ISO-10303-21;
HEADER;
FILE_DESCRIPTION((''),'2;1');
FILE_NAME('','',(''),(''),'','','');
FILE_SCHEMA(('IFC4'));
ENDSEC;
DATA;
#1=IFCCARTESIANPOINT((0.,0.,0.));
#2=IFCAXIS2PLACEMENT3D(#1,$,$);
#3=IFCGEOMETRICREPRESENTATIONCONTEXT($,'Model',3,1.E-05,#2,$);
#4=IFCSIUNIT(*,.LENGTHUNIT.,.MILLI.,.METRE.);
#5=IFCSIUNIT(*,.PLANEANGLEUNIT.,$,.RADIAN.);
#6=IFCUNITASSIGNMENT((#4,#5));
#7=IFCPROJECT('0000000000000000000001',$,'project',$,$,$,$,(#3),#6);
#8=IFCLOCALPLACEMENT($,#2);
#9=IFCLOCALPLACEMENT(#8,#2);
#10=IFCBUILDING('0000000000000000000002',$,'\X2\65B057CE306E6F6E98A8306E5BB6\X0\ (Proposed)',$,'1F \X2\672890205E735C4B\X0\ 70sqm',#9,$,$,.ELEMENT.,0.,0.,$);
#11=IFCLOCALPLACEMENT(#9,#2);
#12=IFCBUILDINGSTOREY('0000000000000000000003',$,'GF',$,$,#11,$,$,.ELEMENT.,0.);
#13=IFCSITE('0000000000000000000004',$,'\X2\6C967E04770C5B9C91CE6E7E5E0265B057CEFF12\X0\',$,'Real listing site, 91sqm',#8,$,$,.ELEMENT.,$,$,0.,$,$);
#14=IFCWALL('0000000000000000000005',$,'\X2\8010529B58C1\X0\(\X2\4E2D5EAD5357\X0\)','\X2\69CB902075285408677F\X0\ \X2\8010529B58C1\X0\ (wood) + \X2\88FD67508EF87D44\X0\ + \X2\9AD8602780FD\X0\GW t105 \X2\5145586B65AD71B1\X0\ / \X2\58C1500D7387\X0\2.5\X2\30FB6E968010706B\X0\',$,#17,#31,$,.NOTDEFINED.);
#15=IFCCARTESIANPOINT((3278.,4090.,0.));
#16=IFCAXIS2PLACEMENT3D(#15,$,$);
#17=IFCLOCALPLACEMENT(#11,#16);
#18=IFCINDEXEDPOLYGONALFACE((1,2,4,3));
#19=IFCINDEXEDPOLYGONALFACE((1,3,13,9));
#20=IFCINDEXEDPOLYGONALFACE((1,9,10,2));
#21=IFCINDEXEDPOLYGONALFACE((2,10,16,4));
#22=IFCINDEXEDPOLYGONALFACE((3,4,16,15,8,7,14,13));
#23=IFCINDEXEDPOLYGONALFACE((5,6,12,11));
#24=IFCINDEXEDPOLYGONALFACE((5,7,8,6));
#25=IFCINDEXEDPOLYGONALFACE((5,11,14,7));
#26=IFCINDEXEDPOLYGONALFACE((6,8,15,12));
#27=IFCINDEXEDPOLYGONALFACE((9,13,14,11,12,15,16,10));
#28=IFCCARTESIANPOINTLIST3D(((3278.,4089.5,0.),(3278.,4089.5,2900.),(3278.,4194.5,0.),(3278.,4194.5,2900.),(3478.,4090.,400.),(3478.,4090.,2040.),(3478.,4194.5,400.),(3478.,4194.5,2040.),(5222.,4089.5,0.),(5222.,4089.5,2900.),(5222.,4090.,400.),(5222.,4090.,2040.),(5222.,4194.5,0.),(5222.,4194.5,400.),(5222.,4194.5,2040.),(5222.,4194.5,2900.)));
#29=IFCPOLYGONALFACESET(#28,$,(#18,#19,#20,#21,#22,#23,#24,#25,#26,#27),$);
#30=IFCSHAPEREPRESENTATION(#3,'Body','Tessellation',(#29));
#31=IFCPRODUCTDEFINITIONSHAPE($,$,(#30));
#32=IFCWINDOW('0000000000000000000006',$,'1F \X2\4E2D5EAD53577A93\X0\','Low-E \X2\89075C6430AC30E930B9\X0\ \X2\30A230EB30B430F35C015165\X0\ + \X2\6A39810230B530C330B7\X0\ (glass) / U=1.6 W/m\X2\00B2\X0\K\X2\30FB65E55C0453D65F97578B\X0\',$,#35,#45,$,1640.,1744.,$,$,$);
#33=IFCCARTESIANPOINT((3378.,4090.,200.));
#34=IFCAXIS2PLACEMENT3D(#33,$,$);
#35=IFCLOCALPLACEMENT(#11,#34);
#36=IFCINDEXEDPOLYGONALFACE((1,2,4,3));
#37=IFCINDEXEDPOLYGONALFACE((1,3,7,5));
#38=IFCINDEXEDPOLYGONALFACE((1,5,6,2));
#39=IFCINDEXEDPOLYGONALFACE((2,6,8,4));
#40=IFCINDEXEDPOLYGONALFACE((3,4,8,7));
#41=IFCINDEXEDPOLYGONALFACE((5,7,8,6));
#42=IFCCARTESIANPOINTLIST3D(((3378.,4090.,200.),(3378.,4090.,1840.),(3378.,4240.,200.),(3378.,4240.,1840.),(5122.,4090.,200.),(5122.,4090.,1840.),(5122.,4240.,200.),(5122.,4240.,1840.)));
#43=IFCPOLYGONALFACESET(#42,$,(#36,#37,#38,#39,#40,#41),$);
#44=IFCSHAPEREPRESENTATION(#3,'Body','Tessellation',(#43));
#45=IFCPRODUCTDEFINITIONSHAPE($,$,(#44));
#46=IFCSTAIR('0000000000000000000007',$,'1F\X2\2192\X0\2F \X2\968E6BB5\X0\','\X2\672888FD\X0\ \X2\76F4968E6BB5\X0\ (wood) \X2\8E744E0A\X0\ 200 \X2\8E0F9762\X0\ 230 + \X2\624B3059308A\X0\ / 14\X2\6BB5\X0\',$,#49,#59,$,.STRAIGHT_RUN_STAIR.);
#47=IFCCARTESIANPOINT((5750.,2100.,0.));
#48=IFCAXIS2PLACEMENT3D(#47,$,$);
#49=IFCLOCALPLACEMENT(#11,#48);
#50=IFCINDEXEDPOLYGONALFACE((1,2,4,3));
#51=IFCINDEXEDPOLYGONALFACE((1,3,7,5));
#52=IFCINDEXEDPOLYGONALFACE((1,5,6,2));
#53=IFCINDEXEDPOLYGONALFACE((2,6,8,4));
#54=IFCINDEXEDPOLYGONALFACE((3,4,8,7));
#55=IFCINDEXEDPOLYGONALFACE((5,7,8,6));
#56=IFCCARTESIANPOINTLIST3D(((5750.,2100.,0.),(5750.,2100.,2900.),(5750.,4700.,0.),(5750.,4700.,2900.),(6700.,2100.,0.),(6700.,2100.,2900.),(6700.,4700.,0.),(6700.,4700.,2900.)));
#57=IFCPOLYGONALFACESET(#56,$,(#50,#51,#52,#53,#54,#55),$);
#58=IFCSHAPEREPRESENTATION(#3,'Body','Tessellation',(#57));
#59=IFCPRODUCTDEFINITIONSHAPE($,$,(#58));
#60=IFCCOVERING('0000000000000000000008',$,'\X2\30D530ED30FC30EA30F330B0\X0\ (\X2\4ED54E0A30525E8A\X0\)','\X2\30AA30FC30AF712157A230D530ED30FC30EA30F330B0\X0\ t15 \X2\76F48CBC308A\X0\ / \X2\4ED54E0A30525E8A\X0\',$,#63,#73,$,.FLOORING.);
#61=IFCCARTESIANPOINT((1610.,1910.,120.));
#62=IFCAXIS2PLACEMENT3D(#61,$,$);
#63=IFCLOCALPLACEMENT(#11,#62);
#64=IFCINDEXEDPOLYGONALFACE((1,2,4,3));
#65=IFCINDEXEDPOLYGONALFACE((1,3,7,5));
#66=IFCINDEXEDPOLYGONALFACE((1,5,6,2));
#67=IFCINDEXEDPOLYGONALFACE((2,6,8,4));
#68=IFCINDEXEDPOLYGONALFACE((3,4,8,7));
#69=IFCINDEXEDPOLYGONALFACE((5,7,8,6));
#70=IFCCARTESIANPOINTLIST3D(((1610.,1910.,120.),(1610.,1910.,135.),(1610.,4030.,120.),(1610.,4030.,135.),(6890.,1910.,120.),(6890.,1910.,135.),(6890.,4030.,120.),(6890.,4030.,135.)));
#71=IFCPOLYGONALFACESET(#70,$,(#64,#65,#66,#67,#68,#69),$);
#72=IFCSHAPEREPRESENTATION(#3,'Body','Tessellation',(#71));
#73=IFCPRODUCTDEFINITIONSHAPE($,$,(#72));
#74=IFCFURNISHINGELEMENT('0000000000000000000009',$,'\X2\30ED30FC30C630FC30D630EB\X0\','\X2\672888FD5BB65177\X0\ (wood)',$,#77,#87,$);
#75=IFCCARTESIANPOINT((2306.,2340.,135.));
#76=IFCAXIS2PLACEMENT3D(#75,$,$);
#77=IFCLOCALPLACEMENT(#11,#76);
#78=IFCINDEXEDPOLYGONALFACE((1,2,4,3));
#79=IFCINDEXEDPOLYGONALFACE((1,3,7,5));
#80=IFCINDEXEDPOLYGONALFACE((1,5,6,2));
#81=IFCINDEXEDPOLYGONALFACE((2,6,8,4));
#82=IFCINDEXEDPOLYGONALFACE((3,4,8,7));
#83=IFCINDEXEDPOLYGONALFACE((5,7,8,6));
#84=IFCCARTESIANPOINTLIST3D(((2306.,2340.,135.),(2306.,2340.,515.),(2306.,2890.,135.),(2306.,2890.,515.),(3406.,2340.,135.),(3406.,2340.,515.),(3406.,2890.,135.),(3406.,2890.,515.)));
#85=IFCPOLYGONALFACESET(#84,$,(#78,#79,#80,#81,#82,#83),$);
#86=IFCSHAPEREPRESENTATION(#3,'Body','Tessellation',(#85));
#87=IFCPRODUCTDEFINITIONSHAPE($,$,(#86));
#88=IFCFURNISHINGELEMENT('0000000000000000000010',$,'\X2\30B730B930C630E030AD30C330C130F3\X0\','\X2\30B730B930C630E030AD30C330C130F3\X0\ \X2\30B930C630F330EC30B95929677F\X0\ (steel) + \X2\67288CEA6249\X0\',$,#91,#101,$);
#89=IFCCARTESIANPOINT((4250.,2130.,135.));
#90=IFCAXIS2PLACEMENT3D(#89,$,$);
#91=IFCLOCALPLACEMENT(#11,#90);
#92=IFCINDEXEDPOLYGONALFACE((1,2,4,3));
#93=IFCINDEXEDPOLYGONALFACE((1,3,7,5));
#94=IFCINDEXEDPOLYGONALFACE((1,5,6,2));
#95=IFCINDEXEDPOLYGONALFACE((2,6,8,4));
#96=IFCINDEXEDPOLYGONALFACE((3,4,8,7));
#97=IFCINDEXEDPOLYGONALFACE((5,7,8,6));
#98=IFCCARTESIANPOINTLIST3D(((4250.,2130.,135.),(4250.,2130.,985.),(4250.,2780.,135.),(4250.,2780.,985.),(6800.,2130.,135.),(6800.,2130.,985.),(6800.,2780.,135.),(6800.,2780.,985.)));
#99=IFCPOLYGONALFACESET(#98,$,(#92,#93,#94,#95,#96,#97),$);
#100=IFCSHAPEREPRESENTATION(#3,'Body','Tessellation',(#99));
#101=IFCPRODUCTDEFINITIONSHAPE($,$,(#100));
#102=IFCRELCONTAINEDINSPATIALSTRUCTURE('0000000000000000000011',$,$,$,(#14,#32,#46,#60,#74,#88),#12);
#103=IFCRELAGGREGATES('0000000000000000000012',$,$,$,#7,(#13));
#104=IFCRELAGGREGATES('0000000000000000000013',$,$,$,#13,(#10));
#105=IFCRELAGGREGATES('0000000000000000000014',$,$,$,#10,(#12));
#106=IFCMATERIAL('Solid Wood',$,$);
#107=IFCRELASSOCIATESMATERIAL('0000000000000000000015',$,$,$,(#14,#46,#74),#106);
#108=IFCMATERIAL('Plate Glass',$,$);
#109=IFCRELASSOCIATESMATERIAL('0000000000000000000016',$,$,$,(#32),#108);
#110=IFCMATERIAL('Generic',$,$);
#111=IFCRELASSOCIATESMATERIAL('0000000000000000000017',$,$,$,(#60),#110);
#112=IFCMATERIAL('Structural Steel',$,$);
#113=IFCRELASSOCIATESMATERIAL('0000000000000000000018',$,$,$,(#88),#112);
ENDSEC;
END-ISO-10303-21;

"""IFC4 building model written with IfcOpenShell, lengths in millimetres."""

from ifc_helpers import new_model, si_unit, frame, frame_2d, origin, place, context, project, spatial, rectangle, extrude, material, element, fill, save


model = new_model("IFC4")

# Units and contexts
model_context = context("Model", 3, precision=1e-05, world=origin())
ifc_project = project(units=[si_unit("LENGTHUNIT", "METRE", prefix="MILLI"), si_unit("PLANEANGLEUNIT", "RADIAN")], contexts=[model_context])

# Site, building, storey
site_placement = place(None, origin())
site = spatial("IfcSite", under=ifc_project, at=site_placement, Name="沖縄県宜野湾市新城２", ObjectType="Real listing site, 91sqm", CompositionType="ELEMENT", RefElevation=0.0)
building_placement = place(site_placement, origin())
building = spatial("IfcBuilding", under=site, at=building_placement, Name="新城の潮風の家 (Proposed)", ObjectType="1F 木造平屋 70sqm", CompositionType="ELEMENT", ElevationOfRefHeight=0.0, ElevationOfTerrain=0.0)
storey_placement = place(building_placement, origin())
storey = spatial("IfcBuildingStorey", under=building, at=storey_placement, Name="GF", CompositionType="ELEMENT", Elevation=0.0)

# Shared definitions
ifc_material_1 = material(Name="Solid Wood")

# Shared definitions
ifc_material_2 = material(Name="Plate Glass")

# Wall, opening, window
wall_1_placement = place(storey_placement, frame((3278.0, 4090.0, 0.0)))
wall_1 = element("IfcWall", 1, at=wall_1_placement, inside=storey, material=ifc_material_1, Name="耐力壁(中庭南)", Description="構造用合板 耐力壁 (wood) + 製材軸組 + 高性能GW t105 充填断熱 / 壁倍率2.5・準耐火", PredefinedType="NOTDEFINED", context=model_context, shape_type="SweptSolid", body=[
    extrude(rectangle(XDim=1944.0, YDim=105.0, at=frame_2d((972.0, 52.0))), frame((3278.0, 4090.0, 0.0)), (0.0, 0.0, 1.0), 2900.0),
])
opening_1_placement = place(storey_placement, frame((3378.0, 4090.0, 200.0)))
opening_1 = element("IfcOpeningElement", 2, at=opening_1_placement, cuts=wall_1, PredefinedType="NOTDEFINED", context=model_context, shape_type="SweptSolid", body=[
    extrude(rectangle(XDim=1744.0, YDim=150.0, at=frame_2d((872.0, 75.0))), frame((3378.0, 4090.0, 200.0)), (0.0, 0.0, 1.0), 1640.0),
])
window_1_placement = place(storey_placement, frame((3378.0, 4090.0, 200.0)))
window_1 = element("IfcWindow", 3, at=window_1_placement, inside=storey, material=ifc_material_2, Name="1F 中庭南窓", Description="Low-E 複層ガラス アルゴン封入 + 樹脂サッシ (glass) / U=1.6 W/m²K・日射取得型", OverallHeight=1640.0, OverallWidth=1744.0, context=model_context, shape_type="SweptSolid", body=[
    extrude(rectangle(XDim=1744.0, YDim=150.0, at=frame_2d((872.0, 75.0))), frame((3378.0, 4090.0, 200.0)), (0.0, 0.0, 1.0), 1640.0),
])
fill(opening_1, window_1)

# Stair
stair_placement = place(storey_placement, frame((5750.0, 2100.0, 0.0)))
element("IfcStair", 4, at=stair_placement, inside=storey, material=ifc_material_1, Name="1F→2F 階段", Description="木製 直階段 (wood) 蹴上 200 踏面 230 + 手すり / 14段", PredefinedType="STRAIGHT_RUN_STAIR", context=model_context, shape_type="SweptSolid", body=[
    extrude(rectangle(XDim=950.0, YDim=2600.0, at=frame_2d((475.0, 1300.0))), frame((5750.0, 2100.0, 0.0)), (0.0, 0.0, 1.0), 2900.0),
])

# Covering
ifc_material_3 = material(Name="Generic")
covering_placement = place(storey_placement, frame((1610.0, 1910.0, 120.0)))
element("IfcCovering", 5, at=covering_placement, inside=storey, material=ifc_material_3, Name="フローリング (仕上げ床)", Description="オーク無垢フローリング t15 直貼り / 仕上げ床", PredefinedType="FLOORING", context=model_context, shape_type="SweptSolid", body=[
    extrude(rectangle(XDim=5280.0, YDim=2120.0, at=frame_2d((2640.0, 1060.0))), frame((1610.0, 1910.0, 120.0)), (0.0, 0.0, 1.0), 15.0),
])

# Furnishing elements
furnishing_1_placement = place(storey_placement, frame((2306.0, 2340.0, 135.0)))
element("IfcFurnishingElement", 6, at=furnishing_1_placement, inside=storey, material=ifc_material_1, Name="ローテーブル", Description="木製家具 (wood)", context=model_context, shape_type="SweptSolid", body=[
    extrude(rectangle(XDim=1100.0, YDim=550.0, at=frame_2d((550.0, 275.0))), frame((2306.0, 2340.0, 135.0)), (0.0, 0.0, 1.0), 380.0),
])
ifc_material_4 = material(Name="Structural Steel")
furnishing_2_placement = place(storey_placement, frame((4250.0, 2130.0, 135.0)))
element("IfcFurnishingElement", 7, at=furnishing_2_placement, inside=storey, material=ifc_material_4, Name="システムキッチン", Description="システムキッチン ステンレス天板 (steel) + 木質扉", context=model_context, shape_type="SweptSolid", body=[
    extrude(rectangle(XDim=2550.0, YDim=650.0, at=frame_2d((1275.0, 325.0))), frame((4250.0, 2130.0, 135.0)), (0.0, 0.0, 1.0), 850.0),
])

save(model, "model.ifc")
